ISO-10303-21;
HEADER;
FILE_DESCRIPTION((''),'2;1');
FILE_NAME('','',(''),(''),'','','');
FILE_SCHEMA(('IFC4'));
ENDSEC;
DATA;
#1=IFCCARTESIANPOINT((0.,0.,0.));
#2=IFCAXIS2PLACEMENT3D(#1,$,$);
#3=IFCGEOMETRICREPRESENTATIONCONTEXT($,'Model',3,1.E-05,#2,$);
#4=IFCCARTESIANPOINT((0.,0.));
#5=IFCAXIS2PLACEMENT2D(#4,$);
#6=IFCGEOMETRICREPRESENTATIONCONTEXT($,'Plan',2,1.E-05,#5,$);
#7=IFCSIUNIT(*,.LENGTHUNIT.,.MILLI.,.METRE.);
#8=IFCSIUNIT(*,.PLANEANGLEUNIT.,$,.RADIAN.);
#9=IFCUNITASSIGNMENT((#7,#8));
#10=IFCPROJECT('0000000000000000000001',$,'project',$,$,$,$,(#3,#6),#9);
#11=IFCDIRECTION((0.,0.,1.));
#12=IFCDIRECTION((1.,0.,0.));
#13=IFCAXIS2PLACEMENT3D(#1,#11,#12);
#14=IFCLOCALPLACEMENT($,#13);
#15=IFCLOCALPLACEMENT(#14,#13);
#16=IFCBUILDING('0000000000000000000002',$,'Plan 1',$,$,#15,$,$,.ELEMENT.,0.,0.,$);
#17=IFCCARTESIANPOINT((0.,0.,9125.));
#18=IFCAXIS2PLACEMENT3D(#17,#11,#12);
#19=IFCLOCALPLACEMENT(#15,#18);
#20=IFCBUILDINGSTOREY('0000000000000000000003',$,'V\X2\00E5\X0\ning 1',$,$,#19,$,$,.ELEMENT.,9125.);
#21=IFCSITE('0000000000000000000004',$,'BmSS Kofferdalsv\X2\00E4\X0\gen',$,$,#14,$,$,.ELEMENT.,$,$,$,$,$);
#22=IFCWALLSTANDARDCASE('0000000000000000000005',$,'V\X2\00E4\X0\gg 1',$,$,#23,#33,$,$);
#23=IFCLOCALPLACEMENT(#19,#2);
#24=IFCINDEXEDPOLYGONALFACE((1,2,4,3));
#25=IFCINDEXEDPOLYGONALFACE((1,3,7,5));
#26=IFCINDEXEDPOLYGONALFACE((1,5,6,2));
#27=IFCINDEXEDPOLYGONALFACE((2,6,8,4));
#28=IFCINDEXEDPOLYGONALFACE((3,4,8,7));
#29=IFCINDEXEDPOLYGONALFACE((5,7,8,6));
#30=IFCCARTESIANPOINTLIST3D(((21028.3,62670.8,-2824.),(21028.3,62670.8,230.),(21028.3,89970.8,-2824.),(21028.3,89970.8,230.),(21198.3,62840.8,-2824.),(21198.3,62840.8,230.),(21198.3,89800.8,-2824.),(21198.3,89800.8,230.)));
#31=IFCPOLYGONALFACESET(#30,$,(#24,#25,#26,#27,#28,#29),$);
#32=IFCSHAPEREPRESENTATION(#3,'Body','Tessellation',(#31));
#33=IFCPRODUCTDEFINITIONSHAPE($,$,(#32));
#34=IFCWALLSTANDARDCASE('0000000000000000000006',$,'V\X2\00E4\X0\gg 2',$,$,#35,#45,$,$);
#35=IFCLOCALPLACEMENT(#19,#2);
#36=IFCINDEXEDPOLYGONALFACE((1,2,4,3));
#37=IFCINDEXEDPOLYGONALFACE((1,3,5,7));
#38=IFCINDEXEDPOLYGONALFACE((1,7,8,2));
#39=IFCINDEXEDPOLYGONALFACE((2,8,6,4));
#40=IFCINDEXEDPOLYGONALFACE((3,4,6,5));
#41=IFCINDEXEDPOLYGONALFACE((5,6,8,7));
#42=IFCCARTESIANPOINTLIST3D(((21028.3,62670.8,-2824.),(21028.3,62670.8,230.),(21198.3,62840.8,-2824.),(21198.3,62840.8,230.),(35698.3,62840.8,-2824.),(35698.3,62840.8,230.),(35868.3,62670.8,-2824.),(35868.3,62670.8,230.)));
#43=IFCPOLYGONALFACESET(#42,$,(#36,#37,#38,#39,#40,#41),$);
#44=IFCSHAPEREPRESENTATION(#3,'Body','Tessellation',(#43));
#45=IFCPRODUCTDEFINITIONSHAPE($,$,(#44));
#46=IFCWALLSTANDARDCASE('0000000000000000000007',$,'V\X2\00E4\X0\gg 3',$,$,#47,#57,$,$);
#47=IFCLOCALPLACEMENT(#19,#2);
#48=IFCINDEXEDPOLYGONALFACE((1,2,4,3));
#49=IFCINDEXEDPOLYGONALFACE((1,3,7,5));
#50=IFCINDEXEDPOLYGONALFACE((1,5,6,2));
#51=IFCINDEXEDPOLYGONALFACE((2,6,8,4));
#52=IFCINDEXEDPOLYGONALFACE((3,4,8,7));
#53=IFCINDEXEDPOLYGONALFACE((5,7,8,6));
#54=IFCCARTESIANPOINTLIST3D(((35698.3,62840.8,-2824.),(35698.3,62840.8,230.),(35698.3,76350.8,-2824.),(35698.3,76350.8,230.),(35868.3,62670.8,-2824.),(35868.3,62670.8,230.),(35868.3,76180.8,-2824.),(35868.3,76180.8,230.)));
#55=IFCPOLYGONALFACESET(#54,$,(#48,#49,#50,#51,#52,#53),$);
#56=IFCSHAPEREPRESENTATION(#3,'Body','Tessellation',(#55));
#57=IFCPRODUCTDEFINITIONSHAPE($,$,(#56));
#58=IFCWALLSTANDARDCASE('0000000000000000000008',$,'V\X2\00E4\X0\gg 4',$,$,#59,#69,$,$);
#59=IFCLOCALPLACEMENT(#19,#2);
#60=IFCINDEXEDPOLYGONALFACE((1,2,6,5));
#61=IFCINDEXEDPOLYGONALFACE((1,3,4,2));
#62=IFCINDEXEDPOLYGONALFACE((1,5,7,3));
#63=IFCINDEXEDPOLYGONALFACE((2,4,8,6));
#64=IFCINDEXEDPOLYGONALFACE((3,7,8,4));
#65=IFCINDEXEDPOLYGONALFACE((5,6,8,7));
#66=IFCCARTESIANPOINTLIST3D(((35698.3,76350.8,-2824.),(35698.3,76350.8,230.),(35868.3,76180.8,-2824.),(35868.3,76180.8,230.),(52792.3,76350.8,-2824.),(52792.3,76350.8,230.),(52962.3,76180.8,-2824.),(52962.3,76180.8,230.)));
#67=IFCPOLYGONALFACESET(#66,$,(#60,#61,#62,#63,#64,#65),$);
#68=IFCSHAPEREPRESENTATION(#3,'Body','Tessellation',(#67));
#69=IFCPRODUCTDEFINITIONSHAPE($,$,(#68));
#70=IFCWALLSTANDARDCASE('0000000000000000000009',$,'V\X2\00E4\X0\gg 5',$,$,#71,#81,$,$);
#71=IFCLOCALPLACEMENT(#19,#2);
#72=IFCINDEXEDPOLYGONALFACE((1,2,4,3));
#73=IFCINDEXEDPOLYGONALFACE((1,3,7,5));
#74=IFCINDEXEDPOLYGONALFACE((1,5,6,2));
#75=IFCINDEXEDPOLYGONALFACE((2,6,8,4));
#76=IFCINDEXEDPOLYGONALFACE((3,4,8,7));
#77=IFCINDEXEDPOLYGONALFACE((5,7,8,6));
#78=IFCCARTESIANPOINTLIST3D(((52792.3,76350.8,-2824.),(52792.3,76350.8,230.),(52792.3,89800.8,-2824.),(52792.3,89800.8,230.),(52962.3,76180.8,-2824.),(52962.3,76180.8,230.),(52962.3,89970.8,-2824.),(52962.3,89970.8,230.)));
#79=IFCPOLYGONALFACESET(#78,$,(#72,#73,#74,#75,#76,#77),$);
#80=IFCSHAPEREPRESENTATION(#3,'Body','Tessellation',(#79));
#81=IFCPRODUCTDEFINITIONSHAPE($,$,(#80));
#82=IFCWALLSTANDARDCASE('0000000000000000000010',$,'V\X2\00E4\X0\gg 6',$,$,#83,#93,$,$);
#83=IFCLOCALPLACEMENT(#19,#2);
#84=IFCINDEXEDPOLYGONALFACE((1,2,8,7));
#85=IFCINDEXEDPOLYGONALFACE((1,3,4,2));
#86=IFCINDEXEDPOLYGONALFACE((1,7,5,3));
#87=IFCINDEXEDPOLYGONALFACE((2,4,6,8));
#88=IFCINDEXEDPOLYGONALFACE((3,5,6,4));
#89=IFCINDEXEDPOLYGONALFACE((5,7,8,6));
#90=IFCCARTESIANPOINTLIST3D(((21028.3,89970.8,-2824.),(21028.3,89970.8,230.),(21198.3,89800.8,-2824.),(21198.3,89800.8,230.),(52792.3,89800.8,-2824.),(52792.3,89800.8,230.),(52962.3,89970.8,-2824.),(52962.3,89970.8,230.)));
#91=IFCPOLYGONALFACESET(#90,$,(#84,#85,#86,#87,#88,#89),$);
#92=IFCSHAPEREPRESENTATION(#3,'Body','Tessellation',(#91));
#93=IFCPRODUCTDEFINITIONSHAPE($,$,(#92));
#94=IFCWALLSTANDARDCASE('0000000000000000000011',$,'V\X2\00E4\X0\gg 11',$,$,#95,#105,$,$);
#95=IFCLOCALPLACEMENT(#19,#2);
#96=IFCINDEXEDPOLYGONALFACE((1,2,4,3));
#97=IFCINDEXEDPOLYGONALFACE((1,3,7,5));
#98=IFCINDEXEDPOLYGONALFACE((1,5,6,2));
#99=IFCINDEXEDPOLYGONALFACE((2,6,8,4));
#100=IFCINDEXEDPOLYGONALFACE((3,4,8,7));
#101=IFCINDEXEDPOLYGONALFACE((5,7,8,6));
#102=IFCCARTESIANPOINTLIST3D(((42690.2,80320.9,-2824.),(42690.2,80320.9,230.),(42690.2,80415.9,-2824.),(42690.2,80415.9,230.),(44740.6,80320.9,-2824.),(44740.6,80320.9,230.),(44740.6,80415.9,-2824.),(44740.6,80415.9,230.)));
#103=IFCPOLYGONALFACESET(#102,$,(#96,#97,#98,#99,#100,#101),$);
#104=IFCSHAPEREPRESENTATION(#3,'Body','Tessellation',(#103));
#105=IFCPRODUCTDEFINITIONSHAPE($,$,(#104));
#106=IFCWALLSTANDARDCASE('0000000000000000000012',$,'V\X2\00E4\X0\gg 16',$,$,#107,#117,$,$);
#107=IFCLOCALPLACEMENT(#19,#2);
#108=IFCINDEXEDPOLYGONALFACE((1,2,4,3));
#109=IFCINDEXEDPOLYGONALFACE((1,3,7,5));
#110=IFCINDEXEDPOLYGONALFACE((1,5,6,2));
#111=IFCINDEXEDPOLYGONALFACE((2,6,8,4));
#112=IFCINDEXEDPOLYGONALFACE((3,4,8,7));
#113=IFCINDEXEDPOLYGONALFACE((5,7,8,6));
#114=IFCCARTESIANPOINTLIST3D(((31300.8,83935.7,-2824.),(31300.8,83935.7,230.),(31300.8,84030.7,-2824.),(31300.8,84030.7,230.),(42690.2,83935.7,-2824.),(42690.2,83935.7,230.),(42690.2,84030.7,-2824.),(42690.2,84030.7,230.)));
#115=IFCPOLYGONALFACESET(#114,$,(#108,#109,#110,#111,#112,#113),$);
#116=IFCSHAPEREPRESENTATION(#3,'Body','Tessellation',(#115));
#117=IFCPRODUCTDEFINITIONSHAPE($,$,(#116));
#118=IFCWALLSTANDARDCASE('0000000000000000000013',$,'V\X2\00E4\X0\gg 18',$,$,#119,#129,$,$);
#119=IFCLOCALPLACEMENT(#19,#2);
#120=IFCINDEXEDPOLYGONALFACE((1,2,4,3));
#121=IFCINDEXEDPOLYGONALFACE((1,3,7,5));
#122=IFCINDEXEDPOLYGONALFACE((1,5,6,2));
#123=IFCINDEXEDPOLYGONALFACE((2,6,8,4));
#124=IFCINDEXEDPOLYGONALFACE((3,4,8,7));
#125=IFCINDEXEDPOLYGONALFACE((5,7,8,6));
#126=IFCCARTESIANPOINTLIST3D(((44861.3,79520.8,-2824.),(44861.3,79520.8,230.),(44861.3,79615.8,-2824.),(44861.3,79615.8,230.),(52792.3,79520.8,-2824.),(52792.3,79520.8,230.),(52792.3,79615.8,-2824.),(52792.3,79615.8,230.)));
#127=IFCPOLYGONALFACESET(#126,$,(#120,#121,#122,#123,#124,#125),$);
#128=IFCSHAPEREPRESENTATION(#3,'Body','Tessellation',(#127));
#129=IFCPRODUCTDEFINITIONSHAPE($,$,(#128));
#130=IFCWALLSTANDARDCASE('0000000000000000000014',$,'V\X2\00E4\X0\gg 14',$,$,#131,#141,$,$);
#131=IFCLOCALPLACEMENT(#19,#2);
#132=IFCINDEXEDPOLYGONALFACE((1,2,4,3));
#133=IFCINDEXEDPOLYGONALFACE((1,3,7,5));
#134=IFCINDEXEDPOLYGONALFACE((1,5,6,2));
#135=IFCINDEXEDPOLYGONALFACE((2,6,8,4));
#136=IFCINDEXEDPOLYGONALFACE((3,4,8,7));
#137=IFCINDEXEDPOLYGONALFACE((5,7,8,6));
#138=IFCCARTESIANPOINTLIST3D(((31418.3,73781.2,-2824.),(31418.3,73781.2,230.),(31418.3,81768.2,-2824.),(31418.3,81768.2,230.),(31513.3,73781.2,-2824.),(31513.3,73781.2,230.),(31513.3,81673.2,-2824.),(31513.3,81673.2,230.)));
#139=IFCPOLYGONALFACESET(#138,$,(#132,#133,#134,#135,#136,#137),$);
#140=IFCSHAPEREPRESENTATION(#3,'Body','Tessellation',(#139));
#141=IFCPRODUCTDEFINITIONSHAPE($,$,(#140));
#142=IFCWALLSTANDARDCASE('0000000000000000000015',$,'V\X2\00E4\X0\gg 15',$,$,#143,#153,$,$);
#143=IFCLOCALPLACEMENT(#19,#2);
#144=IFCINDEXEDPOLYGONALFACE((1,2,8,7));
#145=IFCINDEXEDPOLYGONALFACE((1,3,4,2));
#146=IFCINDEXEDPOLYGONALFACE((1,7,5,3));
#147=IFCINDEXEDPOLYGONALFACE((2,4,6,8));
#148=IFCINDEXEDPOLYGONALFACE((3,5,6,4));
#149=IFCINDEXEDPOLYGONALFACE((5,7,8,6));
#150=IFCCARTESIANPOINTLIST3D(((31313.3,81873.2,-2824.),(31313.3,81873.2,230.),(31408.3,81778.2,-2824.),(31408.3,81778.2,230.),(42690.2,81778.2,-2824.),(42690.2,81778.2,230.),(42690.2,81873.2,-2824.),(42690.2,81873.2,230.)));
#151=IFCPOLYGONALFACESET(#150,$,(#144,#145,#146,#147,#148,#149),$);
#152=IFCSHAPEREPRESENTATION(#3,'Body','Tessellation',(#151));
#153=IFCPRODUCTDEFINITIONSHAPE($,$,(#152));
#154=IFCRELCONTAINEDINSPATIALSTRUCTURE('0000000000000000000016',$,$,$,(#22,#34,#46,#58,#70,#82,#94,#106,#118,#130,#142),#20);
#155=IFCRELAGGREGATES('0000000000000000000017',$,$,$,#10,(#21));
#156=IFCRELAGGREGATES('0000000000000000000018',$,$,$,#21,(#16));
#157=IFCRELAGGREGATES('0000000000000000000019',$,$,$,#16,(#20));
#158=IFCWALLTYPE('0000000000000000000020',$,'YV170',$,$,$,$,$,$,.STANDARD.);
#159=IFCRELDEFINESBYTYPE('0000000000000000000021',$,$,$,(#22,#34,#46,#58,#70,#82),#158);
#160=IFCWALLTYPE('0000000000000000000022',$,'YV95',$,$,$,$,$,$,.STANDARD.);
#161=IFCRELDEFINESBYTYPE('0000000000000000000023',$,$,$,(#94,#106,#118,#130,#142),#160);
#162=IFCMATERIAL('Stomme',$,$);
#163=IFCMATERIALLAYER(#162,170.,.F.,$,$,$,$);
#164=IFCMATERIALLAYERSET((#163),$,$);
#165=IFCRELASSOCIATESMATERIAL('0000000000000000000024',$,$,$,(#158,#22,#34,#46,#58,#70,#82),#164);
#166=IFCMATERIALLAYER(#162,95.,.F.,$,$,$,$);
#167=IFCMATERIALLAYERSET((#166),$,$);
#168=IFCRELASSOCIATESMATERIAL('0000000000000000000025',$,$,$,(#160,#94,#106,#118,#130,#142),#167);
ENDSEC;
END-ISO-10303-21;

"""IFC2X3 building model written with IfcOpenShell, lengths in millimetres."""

from ifc_helpers import new_model, si_unit, frame, origin, origin_with_axes, origin_2d, place, context, project, spatial, polyline, segment, composite_curve, outline, extrude, material, layer, layer_set, layer_usage, type_object, element, save


model = new_model("IFC2X3")

# Units and contexts
model_context = context("Model", 3, precision=1e-05, world=origin())
plan_context = context("Plan", 2, precision=1e-05, world=origin_2d())
ifc_project = project(units=[si_unit("LENGTHUNIT", "METRE", prefix="MILLI"), si_unit("PLANEANGLEUNIT", "RADIAN")], contexts=[model_context, plan_context])

# Site, building, storey
site_placement = place(None, origin_with_axes())
site = spatial("IfcSite", under=ifc_project, at=site_placement, Name="BmSS Kofferdalsvägen", CompositionType="ELEMENT")
building_placement = place(site_placement, origin_with_axes())
building = spatial("IfcBuilding", under=site, at=building_placement, Name="Plan 1", CompositionType="ELEMENT", ElevationOfRefHeight=0.0, ElevationOfTerrain=0.0)
storey_placement = place(building_placement, frame((0.0, 0.0, 9125.0), z_axis=(0.0, 0.0, 1.0), x_axis=(1.0, 0.0, 0.0)))
storey = spatial("IfcBuildingStorey", under=building, at=storey_placement, Name="Våning 1", CompositionType="ELEMENT", Elevation=9125.0)

# Walls
ifc_material = material(Name="Stomme")
ifc_layer_1 = layer(ifc_material, 170.0, ventilated=False)
ifc_layer_set_1 = layer_set([ifc_layer_1])
ifc_layer_usage_1 = layer_usage(ifc_layer_set_1, "AXIS2", "POSITIVE", 0.0)
wall_type_1 = type_object("IfcWallType", Name="YV170", PredefinedType="STANDARD", material=ifc_layer_set_1)
wall_1_placement = place(storey_placement, frame((21028.3, 89970.8, -2824.0), z_axis=(0.0, 0.0, 1.0), x_axis=(0.0, -1.0, 0.0)))
element("IfcWallStandardCase", 1, at=wall_1_placement, inside=storey, type_object=wall_type_1, material=ifc_layer_usage_1, Name="Vägg 1", context=model_context, shape_type="SweptSolid", body=[
    extrude(outline(composite_curve([segment(polyline([(170.0, 170.0), (0.0, 0.0)]), True, "CONTINUOUS"), segment(polyline([(0.0, 0.0), (27300.0, 0.0)]), True, "CONTINUOUS"), segment(polyline([(27300.0, 0.0), (27130.0, 170.0)]), True, "CONTINUOUS"), segment(polyline([(27130.0, 170.0), (170.0, 170.0)]), True, "CONTINUOUS")], self_intersect=False)), origin_with_axes(), (0.0, 0.0, 1.0), 3054.0),
])
ifc_layer_usage_2 = layer_usage(ifc_layer_set_1, "AXIS2", "POSITIVE", 0.0)
wall_2_placement = place(storey_placement, frame((21028.3, 62670.8, -2824.0), z_axis=(0.0, 0.0, 1.0), x_axis=(1.0, 0.0, 0.0)))
element("IfcWallStandardCase", 2, at=wall_2_placement, inside=storey, type_object=wall_type_1, material=ifc_layer_usage_2, Name="Vägg 2", context=model_context, shape_type="SweptSolid", body=[
    extrude(outline(composite_curve([segment(polyline([(170.0, 170.0), (0.0, 0.0)]), True, "CONTINUOUS"), segment(polyline([(0.0, 0.0), (14840.0, 0.0)]), True, "CONTINUOUS"), segment(polyline([(14840.0, 0.0), (14670.0, 170.0)]), True, "CONTINUOUS"), segment(polyline([(14670.0, 170.0), (170.0, 170.0)]), True, "CONTINUOUS")], self_intersect=False)), origin_with_axes(), (0.0, 0.0, 1.0), 3054.0),
])
ifc_layer_usage_3 = layer_usage(ifc_layer_set_1, "AXIS2", "POSITIVE", 0.0)
wall_3_placement = place(storey_placement, frame((35868.3, 62670.8, -2824.0), z_axis=(0.0, 0.0, 1.0), x_axis=(0.0, 1.0, 0.0)))
element("IfcWallStandardCase", 3, at=wall_3_placement, inside=storey, type_object=wall_type_1, material=ifc_layer_usage_3, Name="Vägg 3", context=model_context, shape_type="SweptSolid", body=[
    extrude(outline(composite_curve([segment(polyline([(170.0, 170.0), (0.0, 0.0)]), True, "CONTINUOUS"), segment(polyline([(0.0, 0.0), (13510.0, 0.0)]), True, "CONTINUOUS"), segment(polyline([(13510.0, 0.0), (13680.0, 170.0)]), True, "CONTINUOUS"), segment(polyline([(13680.0, 170.0), (170.0, 170.0)]), True, "CONTINUOUS")], self_intersect=False)), origin_with_axes(), (0.0, 0.0, 1.0), 3054.0),
])
ifc_layer_usage_4 = layer_usage(ifc_layer_set_1, "AXIS2", "POSITIVE", 0.0)
wall_4_placement = place(storey_placement, frame((35868.3, 76180.8, -2824.0), z_axis=(0.0, 0.0, 1.0), x_axis=(1.0, 0.0, 0.0)))
element("IfcWallStandardCase", 4, at=wall_4_placement, inside=storey, type_object=wall_type_1, material=ifc_layer_usage_4, Name="Vägg 4", context=model_context, shape_type="SweptSolid", body=[
    extrude(outline(composite_curve([segment(polyline([(-170.0, 170.0), (0.0, 0.0)]), True, "CONTINUOUS"), segment(polyline([(0.0, 0.0), (17094.0, 0.0)]), True, "CONTINUOUS"), segment(polyline([(17094.0, 0.0), (16924.0, 170.0)]), True, "CONTINUOUS"), segment(polyline([(16924.0, 170.0), (-170.0, 170.0)]), True, "CONTINUOUS")], self_intersect=False)), origin_with_axes(), (0.0, 0.0, 1.0), 3054.0),
])
ifc_layer_usage_5 = layer_usage(ifc_layer_set_1, "AXIS2", "POSITIVE", 0.0)
wall_5_placement = place(storey_placement, frame((52962.3, 76180.8, -2824.0), z_axis=(0.0, 0.0, 1.0), x_axis=(0.0, 1.0, 0.0)))
element("IfcWallStandardCase", 5, at=wall_5_placement, inside=storey, type_object=wall_type_1, material=ifc_layer_usage_5, Name="Vägg 5", context=model_context, shape_type="SweptSolid", body=[
    extrude(outline(composite_curve([segment(polyline([(170.0, 170.0), (0.0, 0.0)]), True, "CONTINUOUS"), segment(polyline([(0.0, 0.0), (13790.0, 0.0)]), True, "CONTINUOUS"), segment(polyline([(13790.0, 0.0), (13620.0, 170.0)]), True, "CONTINUOUS"), segment(polyline([(13620.0, 170.0), (170.0, 170.0)]), True, "CONTINUOUS")], self_intersect=False)), origin_with_axes(), (0.0, 0.0, 1.0), 3054.0),
])
ifc_layer_usage_6 = layer_usage(ifc_layer_set_1, "AXIS2", "POSITIVE", 0.0)
wall_6_placement = place(storey_placement, frame((52962.3, 89970.8, -2824.0), z_axis=(0.0, 0.0, 1.0), x_axis=(-1.0, 0.0, 0.0)))
element("IfcWallStandardCase", 6, at=wall_6_placement, inside=storey, type_object=wall_type_1, material=ifc_layer_usage_6, Name="Vägg 6", context=model_context, shape_type="SweptSolid", body=[
    extrude(outline(composite_curve([segment(polyline([(170.0, 170.0), (0.0, 0.0)]), True, "CONTINUOUS"), segment(polyline([(0.0, 0.0), (31934.0, 0.0)]), True, "CONTINUOUS"), segment(polyline([(31934.0, 0.0), (31764.0, 170.0)]), True, "CONTINUOUS"), segment(polyline([(31764.0, 170.0), (170.0, 170.0)]), True, "CONTINUOUS")], self_intersect=False)), origin_with_axes(), (0.0, 0.0, 1.0), 3054.0),
])
ifc_layer_2 = layer(ifc_material, 95.0, ventilated=False)
ifc_layer_set_2 = layer_set([ifc_layer_2])
wall_type_2 = type_object("IfcWallType", Name="YV95", PredefinedType="STANDARD", material=ifc_layer_set_2)
ifc_layer_usage_7 = layer_usage(ifc_layer_set_2, "AXIS2", "POSITIVE", -47.5)
wall_7_placement = place(storey_placement, frame((42690.2, 80368.4, -2824.0), z_axis=(0.0, 0.0, 1.0), x_axis=(1.0, 0.0, 0.0)))
element("IfcWallStandardCase", 7, at=wall_7_placement, inside=storey, type_object=wall_type_2, material=ifc_layer_usage_7, Name="Vägg 11", context=model_context, shape_type="SweptSolid", body=[
    extrude(outline(composite_curve([segment(polyline([(0.0, 47.5), (0.0, -47.5)]), True, "CONTINUOUS"), segment(polyline([(0.0, -47.5), (2050.3, -47.5)]), True, "CONTINUOUS"), segment(polyline([(2050.3, -47.5), (2050.3, 47.5)]), True, "CONTINUOUS"), segment(polyline([(2050.3, 47.5), (0.0, 47.5)]), True, "CONTINUOUS")], self_intersect=False)), origin_with_axes(), (0.0, 0.0, 1.0), 3054.0),
])
ifc_layer_usage_8 = layer_usage(ifc_layer_set_2, "AXIS2", "POSITIVE", 0.0)
wall_8_placement = place(storey_placement, frame((31300.8, 83935.7, -2824.0), z_axis=(0.0, 0.0, 1.0), x_axis=(1.0, 0.0, 0.0)))
element("IfcWallStandardCase", 8, at=wall_8_placement, inside=storey, type_object=wall_type_2, material=ifc_layer_usage_8, Name="Vägg 16", context=model_context, shape_type="SweptSolid", body=[
    extrude(outline(composite_curve([segment(polyline([(0.0, 95.0), (0.0, 0.0)]), True, "CONTINUOUS"), segment(polyline([(0.0, 0.0), (11389.4, 0.0)]), True, "CONTINUOUS"), segment(polyline([(11389.4, 0.0), (11389.4, 95.0)]), True, "CONTINUOUS"), segment(polyline([(11389.4, 95.0), (0.0, 95.0)]), True, "CONTINUOUS")], self_intersect=False)), origin_with_axes(), (0.0, 0.0, 1.0), 3054.0),
])
ifc_layer_usage_9 = layer_usage(ifc_layer_set_2, "AXIS2", "POSITIVE", -95.0)
wall_9_placement = place(storey_placement, frame((44861.3, 79615.8, -2824.0), z_axis=(0.0, 0.0, 1.0), x_axis=(1.0, 0.0, 0.0)))
element("IfcWallStandardCase", 9, at=wall_9_placement, inside=storey, type_object=wall_type_2, material=ifc_layer_usage_9, Name="Vägg 18", context=model_context, shape_type="SweptSolid", body=[
    extrude(outline(composite_curve([segment(polyline([(0.0, 0.0), (0.0, -95.0)]), True, "CONTINUOUS"), segment(polyline([(0.0, -95.0), (7930.9, -95.0)]), True, "CONTINUOUS"), segment(polyline([(7930.9, -95.0), (7930.9, 0.0)]), True, "CONTINUOUS"), segment(polyline([(7930.9, 0.0), (0.0, 0.0)]), True, "CONTINUOUS")], self_intersect=False)), origin_with_axes(), (0.0, 0.0, 1.0), 3054.0),
])
ifc_layer_usage_10 = layer_usage(ifc_layer_set_2, "AXIS2", "POSITIVE", -95.0)
wall_10_placement = place(storey_placement, frame((31418.3, 73781.2, -2824.0), z_axis=(0.0, 0.0, 1.0), x_axis=(0.0, 1.0, 0.0)))
element("IfcWallStandardCase", 10, at=wall_10_placement, inside=storey, type_object=wall_type_2, material=ifc_layer_usage_10, Name="Vägg 14", context=model_context, shape_type="SweptSolid", body=[
    extrude(outline(composite_curve([segment(polyline([(0.0, 0.0), (0.0, -95.0)]), True, "CONTINUOUS"), segment(polyline([(0.0, -95.0), (7892.0, -95.0)]), True, "CONTINUOUS"), segment(polyline([(7892.0, -95.0), (7987.0, 0.0)]), True, "CONTINUOUS"), segment(polyline([(7987.0, 0.0), (0.0, 0.0)]), True, "CONTINUOUS")], self_intersect=False)), origin_with_axes(), (0.0, 0.0, 1.0), 3054.0),
])
ifc_layer_usage_11 = layer_usage(ifc_layer_set_2, "AXIS2", "POSITIVE", -47.5)
wall_11_placement = place(storey_placement, frame((31360.8, 81825.7, -2824.0), z_axis=(0.0, 0.0, 1.0), x_axis=(1.0, 0.0, 0.0)))
element("IfcWallStandardCase", 11, at=wall_11_placement, inside=storey, type_object=wall_type_2, material=ifc_layer_usage_11, Name="Vägg 15", context=model_context, shape_type="SweptSolid", body=[
    extrude(outline(composite_curve([segment(polyline([(-47.5, 47.5), (47.5, -47.5)]), True, "CONTINUOUS"), segment(polyline([(47.5, -47.5), (11329.4, -47.5)]), True, "CONTINUOUS"), segment(polyline([(11329.4, -47.5), (11329.4, 47.5)]), True, "CONTINUOUS"), segment(polyline([(11329.4, 47.5), (-47.5, 47.5)]), True, "CONTINUOUS")], self_intersect=False)), origin_with_axes(), (0.0, 0.0, 1.0), 3054.0),
])

save(model, "model.ifc")
